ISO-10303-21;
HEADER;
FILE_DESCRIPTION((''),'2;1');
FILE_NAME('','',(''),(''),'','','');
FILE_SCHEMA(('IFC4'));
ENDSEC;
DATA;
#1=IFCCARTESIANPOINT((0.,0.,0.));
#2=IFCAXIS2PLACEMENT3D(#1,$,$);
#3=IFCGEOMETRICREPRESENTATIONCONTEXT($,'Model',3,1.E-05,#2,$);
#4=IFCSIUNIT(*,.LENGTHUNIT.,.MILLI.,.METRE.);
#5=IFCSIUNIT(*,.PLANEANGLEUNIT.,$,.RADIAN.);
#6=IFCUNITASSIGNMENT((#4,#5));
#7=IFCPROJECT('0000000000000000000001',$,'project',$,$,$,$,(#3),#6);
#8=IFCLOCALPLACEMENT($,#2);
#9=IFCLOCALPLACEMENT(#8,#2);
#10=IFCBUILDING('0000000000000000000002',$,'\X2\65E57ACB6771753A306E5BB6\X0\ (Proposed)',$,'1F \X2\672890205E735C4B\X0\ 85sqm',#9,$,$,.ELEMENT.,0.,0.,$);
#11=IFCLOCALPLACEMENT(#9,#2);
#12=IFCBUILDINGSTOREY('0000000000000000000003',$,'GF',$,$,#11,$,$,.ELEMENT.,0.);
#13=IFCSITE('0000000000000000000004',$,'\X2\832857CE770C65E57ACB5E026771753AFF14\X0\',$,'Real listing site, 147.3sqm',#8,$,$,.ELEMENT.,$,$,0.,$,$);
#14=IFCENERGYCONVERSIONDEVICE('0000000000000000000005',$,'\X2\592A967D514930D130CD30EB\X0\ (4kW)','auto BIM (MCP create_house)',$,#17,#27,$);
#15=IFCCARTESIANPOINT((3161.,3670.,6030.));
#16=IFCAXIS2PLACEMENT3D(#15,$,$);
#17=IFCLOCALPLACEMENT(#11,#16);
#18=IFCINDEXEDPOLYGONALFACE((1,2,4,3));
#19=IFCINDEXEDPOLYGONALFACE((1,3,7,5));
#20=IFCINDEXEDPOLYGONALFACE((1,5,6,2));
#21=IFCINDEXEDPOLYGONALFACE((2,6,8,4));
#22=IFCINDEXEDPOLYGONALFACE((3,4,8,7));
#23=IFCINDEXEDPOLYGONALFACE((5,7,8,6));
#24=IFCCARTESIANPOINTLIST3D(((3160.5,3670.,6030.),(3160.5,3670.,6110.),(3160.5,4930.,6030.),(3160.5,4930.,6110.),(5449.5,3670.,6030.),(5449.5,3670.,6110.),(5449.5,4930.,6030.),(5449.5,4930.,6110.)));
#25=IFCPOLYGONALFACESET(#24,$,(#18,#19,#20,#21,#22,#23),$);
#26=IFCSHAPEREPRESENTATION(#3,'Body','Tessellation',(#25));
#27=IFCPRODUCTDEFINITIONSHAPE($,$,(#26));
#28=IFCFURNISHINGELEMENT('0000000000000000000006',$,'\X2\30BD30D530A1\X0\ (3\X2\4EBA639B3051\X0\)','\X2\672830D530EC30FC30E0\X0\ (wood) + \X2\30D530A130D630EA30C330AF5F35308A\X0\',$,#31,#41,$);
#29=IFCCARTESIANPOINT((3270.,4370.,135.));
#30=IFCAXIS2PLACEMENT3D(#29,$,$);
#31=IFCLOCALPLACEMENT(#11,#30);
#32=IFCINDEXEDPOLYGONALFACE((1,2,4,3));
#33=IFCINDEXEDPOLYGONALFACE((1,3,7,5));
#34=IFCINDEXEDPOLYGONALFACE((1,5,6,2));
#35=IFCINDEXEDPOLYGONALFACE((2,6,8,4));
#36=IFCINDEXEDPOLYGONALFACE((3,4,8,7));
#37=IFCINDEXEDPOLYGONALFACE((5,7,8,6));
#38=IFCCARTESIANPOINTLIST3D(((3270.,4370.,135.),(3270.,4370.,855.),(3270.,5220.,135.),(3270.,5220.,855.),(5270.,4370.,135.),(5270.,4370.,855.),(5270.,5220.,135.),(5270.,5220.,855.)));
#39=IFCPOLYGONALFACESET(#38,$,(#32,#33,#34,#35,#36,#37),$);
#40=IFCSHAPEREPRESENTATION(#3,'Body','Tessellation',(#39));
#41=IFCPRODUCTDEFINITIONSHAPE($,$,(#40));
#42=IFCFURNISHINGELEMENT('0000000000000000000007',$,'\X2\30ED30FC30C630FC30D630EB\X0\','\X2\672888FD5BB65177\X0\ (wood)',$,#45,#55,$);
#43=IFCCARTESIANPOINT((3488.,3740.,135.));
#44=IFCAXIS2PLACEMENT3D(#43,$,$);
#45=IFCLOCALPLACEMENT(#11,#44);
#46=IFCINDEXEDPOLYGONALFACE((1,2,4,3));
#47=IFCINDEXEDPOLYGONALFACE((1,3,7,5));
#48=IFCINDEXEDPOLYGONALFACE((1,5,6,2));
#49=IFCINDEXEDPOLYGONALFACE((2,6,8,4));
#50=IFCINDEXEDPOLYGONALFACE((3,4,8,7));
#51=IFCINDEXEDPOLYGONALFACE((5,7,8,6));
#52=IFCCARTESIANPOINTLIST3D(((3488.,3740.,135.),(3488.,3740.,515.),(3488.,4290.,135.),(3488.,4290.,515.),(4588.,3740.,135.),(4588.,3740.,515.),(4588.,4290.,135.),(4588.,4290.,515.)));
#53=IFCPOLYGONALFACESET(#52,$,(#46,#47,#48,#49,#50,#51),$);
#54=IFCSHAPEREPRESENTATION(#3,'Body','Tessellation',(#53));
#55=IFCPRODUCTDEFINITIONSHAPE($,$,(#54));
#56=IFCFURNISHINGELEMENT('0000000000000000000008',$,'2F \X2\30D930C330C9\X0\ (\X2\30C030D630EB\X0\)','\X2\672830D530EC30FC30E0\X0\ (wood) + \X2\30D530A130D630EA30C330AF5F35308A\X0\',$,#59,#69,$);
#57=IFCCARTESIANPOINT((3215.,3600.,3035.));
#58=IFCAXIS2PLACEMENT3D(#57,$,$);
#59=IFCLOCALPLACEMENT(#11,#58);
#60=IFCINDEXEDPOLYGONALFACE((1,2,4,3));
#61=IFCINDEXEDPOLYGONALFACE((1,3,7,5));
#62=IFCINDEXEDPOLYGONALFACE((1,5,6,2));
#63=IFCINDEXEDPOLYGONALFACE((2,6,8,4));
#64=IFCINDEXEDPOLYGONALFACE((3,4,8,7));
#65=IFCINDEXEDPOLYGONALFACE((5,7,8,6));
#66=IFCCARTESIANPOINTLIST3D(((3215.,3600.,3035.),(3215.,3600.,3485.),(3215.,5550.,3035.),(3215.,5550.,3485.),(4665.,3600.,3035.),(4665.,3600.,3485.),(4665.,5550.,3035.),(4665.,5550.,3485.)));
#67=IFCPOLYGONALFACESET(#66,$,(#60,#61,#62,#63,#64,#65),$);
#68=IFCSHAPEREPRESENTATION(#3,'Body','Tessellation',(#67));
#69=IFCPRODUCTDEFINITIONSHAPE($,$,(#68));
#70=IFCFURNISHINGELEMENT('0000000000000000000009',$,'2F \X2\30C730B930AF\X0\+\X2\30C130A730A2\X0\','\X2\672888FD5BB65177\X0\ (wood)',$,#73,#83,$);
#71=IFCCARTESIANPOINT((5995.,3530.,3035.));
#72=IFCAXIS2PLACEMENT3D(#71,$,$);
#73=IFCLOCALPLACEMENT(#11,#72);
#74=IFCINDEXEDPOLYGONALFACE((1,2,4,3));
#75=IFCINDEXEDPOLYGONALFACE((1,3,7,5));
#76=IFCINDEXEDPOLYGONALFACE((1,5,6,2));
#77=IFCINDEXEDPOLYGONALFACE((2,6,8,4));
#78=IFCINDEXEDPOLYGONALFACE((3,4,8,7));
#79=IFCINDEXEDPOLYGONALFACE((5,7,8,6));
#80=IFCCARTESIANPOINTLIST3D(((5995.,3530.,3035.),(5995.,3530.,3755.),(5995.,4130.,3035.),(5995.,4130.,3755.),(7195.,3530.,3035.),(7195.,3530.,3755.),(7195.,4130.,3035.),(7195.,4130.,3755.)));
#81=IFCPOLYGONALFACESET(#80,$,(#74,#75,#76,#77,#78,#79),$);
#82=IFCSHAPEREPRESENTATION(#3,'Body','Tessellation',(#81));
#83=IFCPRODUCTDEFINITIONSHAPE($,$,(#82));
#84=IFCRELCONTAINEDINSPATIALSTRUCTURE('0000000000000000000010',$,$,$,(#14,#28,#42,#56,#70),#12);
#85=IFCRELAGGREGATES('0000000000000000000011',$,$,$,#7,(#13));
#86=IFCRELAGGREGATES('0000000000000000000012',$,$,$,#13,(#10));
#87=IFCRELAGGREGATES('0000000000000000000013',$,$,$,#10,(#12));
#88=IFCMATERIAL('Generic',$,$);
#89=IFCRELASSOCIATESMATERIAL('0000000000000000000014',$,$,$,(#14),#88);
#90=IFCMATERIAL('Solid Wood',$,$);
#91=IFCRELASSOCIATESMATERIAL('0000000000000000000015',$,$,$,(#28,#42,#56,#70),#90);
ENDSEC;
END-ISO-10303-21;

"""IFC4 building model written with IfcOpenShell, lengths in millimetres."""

from ifc_helpers import new_model, si_unit, frame, frame_2d, origin, place, context, project, spatial, rectangle, extrude, material, element, save


model = new_model("IFC4")

# Units and contexts
model_context = context("Model", 3, precision=1e-05, world=origin())
ifc_project = project(units=[si_unit("LENGTHUNIT", "METRE", prefix="MILLI"), si_unit("PLANEANGLEUNIT", "RADIAN")], contexts=[model_context])

# Site, building, storey
site_placement = place(None, origin())
site = spatial("IfcSite", under=ifc_project, at=site_placement, Name="茨城県日立市東町４", ObjectType="Real listing site, 147.3sqm", CompositionType="ELEMENT", RefElevation=0.0)
building_placement = place(site_placement, origin())
building = spatial("IfcBuilding", under=site, at=building_placement, Name="日立東町の家 (Proposed)", ObjectType="1F 木造平屋 85sqm", CompositionType="ELEMENT", ElevationOfRefHeight=0.0, ElevationOfTerrain=0.0)
storey_placement = place(building_placement, origin())
storey = spatial("IfcBuildingStorey", under=building, at=storey_placement, Name="GF", CompositionType="ELEMENT", Elevation=0.0)

# Shared definitions
ifc_material_1 = material(Name="Solid Wood")

# Shared definitions
ifc_material_2 = material(Name="Generic")

# Energy conversion device
energy_conversion_device_placement = place(storey_placement, frame((3161.0, 3670.0, 6030.0)))
element("IfcEnergyConversionDevice", 1, at=energy_conversion_device_placement, inside=storey, material=ifc_material_2, Name="太陽光パネル (4kW)", Description="auto BIM (MCP create_house)", context=model_context, shape_type="SweptSolid", body=[
    extrude(rectangle(XDim=2289.0, YDim=1260.0, at=frame_2d((1144.0, 630.0))), frame((3161.0, 3670.0, 6030.0)), (0.0, 0.0, 1.0), 80.0),
])

# Furnishing elements
furnishing_1_placement = place(storey_placement, frame((3270.0, 4370.0, 135.0)))
element("IfcFurnishingElement", 2, at=furnishing_1_placement, inside=storey, material=ifc_material_1, Name="ソファ (3人掛け)", Description="木フレーム (wood) + ファブリック張り", context=model_context, shape_type="SweptSolid", body=[
    extrude(rectangle(XDim=2000.0, YDim=850.0, at=frame_2d((1000.0, 425.0))), frame((3270.0, 4370.0, 135.0)), (0.0, 0.0, 1.0), 720.0),
])
furnishing_2_placement = place(storey_placement, frame((3488.0, 3740.0, 135.0)))
element("IfcFurnishingElement", 3, at=furnishing_2_placement, inside=storey, material=ifc_material_1, Name="ローテーブル", Description="木製家具 (wood)", context=model_context, shape_type="SweptSolid", body=[
    extrude(rectangle(XDim=1100.0, YDim=550.0, at=frame_2d((550.0, 275.0))), frame((3488.0, 3740.0, 135.0)), (0.0, 0.0, 1.0), 380.0),
])
furnishing_3_placement = place(storey_placement, frame((3215.0, 3600.0, 3035.0)))
element("IfcFurnishingElement", 4, at=furnishing_3_placement, inside=storey, material=ifc_material_1, Name="2F ベッド (ダブル)", Description="木フレーム (wood) + ファブリック張り", context=model_context, shape_type="SweptSolid", body=[
    extrude(rectangle(XDim=1450.0, YDim=1950.0, at=frame_2d((725.0, 975.0))), frame((3215.0, 3600.0, 3035.0)), (0.0, 0.0, 1.0), 450.0),
])
furnishing_4_placement = place(storey_placement, frame((5995.0, 3530.0, 3035.0)))
element("IfcFurnishingElement", 5, at=furnishing_4_placement, inside=storey, material=ifc_material_1, Name="2F デスク+チェア", Description="木製家具 (wood)", context=model_context, shape_type="SweptSolid", body=[
    extrude(rectangle(XDim=1200.0, YDim=600.0, at=frame_2d((600.0, 300.0))), frame((5995.0, 3530.0, 3035.0)), (0.0, 0.0, 1.0), 720.0),
])

save(model, "model.ifc")
